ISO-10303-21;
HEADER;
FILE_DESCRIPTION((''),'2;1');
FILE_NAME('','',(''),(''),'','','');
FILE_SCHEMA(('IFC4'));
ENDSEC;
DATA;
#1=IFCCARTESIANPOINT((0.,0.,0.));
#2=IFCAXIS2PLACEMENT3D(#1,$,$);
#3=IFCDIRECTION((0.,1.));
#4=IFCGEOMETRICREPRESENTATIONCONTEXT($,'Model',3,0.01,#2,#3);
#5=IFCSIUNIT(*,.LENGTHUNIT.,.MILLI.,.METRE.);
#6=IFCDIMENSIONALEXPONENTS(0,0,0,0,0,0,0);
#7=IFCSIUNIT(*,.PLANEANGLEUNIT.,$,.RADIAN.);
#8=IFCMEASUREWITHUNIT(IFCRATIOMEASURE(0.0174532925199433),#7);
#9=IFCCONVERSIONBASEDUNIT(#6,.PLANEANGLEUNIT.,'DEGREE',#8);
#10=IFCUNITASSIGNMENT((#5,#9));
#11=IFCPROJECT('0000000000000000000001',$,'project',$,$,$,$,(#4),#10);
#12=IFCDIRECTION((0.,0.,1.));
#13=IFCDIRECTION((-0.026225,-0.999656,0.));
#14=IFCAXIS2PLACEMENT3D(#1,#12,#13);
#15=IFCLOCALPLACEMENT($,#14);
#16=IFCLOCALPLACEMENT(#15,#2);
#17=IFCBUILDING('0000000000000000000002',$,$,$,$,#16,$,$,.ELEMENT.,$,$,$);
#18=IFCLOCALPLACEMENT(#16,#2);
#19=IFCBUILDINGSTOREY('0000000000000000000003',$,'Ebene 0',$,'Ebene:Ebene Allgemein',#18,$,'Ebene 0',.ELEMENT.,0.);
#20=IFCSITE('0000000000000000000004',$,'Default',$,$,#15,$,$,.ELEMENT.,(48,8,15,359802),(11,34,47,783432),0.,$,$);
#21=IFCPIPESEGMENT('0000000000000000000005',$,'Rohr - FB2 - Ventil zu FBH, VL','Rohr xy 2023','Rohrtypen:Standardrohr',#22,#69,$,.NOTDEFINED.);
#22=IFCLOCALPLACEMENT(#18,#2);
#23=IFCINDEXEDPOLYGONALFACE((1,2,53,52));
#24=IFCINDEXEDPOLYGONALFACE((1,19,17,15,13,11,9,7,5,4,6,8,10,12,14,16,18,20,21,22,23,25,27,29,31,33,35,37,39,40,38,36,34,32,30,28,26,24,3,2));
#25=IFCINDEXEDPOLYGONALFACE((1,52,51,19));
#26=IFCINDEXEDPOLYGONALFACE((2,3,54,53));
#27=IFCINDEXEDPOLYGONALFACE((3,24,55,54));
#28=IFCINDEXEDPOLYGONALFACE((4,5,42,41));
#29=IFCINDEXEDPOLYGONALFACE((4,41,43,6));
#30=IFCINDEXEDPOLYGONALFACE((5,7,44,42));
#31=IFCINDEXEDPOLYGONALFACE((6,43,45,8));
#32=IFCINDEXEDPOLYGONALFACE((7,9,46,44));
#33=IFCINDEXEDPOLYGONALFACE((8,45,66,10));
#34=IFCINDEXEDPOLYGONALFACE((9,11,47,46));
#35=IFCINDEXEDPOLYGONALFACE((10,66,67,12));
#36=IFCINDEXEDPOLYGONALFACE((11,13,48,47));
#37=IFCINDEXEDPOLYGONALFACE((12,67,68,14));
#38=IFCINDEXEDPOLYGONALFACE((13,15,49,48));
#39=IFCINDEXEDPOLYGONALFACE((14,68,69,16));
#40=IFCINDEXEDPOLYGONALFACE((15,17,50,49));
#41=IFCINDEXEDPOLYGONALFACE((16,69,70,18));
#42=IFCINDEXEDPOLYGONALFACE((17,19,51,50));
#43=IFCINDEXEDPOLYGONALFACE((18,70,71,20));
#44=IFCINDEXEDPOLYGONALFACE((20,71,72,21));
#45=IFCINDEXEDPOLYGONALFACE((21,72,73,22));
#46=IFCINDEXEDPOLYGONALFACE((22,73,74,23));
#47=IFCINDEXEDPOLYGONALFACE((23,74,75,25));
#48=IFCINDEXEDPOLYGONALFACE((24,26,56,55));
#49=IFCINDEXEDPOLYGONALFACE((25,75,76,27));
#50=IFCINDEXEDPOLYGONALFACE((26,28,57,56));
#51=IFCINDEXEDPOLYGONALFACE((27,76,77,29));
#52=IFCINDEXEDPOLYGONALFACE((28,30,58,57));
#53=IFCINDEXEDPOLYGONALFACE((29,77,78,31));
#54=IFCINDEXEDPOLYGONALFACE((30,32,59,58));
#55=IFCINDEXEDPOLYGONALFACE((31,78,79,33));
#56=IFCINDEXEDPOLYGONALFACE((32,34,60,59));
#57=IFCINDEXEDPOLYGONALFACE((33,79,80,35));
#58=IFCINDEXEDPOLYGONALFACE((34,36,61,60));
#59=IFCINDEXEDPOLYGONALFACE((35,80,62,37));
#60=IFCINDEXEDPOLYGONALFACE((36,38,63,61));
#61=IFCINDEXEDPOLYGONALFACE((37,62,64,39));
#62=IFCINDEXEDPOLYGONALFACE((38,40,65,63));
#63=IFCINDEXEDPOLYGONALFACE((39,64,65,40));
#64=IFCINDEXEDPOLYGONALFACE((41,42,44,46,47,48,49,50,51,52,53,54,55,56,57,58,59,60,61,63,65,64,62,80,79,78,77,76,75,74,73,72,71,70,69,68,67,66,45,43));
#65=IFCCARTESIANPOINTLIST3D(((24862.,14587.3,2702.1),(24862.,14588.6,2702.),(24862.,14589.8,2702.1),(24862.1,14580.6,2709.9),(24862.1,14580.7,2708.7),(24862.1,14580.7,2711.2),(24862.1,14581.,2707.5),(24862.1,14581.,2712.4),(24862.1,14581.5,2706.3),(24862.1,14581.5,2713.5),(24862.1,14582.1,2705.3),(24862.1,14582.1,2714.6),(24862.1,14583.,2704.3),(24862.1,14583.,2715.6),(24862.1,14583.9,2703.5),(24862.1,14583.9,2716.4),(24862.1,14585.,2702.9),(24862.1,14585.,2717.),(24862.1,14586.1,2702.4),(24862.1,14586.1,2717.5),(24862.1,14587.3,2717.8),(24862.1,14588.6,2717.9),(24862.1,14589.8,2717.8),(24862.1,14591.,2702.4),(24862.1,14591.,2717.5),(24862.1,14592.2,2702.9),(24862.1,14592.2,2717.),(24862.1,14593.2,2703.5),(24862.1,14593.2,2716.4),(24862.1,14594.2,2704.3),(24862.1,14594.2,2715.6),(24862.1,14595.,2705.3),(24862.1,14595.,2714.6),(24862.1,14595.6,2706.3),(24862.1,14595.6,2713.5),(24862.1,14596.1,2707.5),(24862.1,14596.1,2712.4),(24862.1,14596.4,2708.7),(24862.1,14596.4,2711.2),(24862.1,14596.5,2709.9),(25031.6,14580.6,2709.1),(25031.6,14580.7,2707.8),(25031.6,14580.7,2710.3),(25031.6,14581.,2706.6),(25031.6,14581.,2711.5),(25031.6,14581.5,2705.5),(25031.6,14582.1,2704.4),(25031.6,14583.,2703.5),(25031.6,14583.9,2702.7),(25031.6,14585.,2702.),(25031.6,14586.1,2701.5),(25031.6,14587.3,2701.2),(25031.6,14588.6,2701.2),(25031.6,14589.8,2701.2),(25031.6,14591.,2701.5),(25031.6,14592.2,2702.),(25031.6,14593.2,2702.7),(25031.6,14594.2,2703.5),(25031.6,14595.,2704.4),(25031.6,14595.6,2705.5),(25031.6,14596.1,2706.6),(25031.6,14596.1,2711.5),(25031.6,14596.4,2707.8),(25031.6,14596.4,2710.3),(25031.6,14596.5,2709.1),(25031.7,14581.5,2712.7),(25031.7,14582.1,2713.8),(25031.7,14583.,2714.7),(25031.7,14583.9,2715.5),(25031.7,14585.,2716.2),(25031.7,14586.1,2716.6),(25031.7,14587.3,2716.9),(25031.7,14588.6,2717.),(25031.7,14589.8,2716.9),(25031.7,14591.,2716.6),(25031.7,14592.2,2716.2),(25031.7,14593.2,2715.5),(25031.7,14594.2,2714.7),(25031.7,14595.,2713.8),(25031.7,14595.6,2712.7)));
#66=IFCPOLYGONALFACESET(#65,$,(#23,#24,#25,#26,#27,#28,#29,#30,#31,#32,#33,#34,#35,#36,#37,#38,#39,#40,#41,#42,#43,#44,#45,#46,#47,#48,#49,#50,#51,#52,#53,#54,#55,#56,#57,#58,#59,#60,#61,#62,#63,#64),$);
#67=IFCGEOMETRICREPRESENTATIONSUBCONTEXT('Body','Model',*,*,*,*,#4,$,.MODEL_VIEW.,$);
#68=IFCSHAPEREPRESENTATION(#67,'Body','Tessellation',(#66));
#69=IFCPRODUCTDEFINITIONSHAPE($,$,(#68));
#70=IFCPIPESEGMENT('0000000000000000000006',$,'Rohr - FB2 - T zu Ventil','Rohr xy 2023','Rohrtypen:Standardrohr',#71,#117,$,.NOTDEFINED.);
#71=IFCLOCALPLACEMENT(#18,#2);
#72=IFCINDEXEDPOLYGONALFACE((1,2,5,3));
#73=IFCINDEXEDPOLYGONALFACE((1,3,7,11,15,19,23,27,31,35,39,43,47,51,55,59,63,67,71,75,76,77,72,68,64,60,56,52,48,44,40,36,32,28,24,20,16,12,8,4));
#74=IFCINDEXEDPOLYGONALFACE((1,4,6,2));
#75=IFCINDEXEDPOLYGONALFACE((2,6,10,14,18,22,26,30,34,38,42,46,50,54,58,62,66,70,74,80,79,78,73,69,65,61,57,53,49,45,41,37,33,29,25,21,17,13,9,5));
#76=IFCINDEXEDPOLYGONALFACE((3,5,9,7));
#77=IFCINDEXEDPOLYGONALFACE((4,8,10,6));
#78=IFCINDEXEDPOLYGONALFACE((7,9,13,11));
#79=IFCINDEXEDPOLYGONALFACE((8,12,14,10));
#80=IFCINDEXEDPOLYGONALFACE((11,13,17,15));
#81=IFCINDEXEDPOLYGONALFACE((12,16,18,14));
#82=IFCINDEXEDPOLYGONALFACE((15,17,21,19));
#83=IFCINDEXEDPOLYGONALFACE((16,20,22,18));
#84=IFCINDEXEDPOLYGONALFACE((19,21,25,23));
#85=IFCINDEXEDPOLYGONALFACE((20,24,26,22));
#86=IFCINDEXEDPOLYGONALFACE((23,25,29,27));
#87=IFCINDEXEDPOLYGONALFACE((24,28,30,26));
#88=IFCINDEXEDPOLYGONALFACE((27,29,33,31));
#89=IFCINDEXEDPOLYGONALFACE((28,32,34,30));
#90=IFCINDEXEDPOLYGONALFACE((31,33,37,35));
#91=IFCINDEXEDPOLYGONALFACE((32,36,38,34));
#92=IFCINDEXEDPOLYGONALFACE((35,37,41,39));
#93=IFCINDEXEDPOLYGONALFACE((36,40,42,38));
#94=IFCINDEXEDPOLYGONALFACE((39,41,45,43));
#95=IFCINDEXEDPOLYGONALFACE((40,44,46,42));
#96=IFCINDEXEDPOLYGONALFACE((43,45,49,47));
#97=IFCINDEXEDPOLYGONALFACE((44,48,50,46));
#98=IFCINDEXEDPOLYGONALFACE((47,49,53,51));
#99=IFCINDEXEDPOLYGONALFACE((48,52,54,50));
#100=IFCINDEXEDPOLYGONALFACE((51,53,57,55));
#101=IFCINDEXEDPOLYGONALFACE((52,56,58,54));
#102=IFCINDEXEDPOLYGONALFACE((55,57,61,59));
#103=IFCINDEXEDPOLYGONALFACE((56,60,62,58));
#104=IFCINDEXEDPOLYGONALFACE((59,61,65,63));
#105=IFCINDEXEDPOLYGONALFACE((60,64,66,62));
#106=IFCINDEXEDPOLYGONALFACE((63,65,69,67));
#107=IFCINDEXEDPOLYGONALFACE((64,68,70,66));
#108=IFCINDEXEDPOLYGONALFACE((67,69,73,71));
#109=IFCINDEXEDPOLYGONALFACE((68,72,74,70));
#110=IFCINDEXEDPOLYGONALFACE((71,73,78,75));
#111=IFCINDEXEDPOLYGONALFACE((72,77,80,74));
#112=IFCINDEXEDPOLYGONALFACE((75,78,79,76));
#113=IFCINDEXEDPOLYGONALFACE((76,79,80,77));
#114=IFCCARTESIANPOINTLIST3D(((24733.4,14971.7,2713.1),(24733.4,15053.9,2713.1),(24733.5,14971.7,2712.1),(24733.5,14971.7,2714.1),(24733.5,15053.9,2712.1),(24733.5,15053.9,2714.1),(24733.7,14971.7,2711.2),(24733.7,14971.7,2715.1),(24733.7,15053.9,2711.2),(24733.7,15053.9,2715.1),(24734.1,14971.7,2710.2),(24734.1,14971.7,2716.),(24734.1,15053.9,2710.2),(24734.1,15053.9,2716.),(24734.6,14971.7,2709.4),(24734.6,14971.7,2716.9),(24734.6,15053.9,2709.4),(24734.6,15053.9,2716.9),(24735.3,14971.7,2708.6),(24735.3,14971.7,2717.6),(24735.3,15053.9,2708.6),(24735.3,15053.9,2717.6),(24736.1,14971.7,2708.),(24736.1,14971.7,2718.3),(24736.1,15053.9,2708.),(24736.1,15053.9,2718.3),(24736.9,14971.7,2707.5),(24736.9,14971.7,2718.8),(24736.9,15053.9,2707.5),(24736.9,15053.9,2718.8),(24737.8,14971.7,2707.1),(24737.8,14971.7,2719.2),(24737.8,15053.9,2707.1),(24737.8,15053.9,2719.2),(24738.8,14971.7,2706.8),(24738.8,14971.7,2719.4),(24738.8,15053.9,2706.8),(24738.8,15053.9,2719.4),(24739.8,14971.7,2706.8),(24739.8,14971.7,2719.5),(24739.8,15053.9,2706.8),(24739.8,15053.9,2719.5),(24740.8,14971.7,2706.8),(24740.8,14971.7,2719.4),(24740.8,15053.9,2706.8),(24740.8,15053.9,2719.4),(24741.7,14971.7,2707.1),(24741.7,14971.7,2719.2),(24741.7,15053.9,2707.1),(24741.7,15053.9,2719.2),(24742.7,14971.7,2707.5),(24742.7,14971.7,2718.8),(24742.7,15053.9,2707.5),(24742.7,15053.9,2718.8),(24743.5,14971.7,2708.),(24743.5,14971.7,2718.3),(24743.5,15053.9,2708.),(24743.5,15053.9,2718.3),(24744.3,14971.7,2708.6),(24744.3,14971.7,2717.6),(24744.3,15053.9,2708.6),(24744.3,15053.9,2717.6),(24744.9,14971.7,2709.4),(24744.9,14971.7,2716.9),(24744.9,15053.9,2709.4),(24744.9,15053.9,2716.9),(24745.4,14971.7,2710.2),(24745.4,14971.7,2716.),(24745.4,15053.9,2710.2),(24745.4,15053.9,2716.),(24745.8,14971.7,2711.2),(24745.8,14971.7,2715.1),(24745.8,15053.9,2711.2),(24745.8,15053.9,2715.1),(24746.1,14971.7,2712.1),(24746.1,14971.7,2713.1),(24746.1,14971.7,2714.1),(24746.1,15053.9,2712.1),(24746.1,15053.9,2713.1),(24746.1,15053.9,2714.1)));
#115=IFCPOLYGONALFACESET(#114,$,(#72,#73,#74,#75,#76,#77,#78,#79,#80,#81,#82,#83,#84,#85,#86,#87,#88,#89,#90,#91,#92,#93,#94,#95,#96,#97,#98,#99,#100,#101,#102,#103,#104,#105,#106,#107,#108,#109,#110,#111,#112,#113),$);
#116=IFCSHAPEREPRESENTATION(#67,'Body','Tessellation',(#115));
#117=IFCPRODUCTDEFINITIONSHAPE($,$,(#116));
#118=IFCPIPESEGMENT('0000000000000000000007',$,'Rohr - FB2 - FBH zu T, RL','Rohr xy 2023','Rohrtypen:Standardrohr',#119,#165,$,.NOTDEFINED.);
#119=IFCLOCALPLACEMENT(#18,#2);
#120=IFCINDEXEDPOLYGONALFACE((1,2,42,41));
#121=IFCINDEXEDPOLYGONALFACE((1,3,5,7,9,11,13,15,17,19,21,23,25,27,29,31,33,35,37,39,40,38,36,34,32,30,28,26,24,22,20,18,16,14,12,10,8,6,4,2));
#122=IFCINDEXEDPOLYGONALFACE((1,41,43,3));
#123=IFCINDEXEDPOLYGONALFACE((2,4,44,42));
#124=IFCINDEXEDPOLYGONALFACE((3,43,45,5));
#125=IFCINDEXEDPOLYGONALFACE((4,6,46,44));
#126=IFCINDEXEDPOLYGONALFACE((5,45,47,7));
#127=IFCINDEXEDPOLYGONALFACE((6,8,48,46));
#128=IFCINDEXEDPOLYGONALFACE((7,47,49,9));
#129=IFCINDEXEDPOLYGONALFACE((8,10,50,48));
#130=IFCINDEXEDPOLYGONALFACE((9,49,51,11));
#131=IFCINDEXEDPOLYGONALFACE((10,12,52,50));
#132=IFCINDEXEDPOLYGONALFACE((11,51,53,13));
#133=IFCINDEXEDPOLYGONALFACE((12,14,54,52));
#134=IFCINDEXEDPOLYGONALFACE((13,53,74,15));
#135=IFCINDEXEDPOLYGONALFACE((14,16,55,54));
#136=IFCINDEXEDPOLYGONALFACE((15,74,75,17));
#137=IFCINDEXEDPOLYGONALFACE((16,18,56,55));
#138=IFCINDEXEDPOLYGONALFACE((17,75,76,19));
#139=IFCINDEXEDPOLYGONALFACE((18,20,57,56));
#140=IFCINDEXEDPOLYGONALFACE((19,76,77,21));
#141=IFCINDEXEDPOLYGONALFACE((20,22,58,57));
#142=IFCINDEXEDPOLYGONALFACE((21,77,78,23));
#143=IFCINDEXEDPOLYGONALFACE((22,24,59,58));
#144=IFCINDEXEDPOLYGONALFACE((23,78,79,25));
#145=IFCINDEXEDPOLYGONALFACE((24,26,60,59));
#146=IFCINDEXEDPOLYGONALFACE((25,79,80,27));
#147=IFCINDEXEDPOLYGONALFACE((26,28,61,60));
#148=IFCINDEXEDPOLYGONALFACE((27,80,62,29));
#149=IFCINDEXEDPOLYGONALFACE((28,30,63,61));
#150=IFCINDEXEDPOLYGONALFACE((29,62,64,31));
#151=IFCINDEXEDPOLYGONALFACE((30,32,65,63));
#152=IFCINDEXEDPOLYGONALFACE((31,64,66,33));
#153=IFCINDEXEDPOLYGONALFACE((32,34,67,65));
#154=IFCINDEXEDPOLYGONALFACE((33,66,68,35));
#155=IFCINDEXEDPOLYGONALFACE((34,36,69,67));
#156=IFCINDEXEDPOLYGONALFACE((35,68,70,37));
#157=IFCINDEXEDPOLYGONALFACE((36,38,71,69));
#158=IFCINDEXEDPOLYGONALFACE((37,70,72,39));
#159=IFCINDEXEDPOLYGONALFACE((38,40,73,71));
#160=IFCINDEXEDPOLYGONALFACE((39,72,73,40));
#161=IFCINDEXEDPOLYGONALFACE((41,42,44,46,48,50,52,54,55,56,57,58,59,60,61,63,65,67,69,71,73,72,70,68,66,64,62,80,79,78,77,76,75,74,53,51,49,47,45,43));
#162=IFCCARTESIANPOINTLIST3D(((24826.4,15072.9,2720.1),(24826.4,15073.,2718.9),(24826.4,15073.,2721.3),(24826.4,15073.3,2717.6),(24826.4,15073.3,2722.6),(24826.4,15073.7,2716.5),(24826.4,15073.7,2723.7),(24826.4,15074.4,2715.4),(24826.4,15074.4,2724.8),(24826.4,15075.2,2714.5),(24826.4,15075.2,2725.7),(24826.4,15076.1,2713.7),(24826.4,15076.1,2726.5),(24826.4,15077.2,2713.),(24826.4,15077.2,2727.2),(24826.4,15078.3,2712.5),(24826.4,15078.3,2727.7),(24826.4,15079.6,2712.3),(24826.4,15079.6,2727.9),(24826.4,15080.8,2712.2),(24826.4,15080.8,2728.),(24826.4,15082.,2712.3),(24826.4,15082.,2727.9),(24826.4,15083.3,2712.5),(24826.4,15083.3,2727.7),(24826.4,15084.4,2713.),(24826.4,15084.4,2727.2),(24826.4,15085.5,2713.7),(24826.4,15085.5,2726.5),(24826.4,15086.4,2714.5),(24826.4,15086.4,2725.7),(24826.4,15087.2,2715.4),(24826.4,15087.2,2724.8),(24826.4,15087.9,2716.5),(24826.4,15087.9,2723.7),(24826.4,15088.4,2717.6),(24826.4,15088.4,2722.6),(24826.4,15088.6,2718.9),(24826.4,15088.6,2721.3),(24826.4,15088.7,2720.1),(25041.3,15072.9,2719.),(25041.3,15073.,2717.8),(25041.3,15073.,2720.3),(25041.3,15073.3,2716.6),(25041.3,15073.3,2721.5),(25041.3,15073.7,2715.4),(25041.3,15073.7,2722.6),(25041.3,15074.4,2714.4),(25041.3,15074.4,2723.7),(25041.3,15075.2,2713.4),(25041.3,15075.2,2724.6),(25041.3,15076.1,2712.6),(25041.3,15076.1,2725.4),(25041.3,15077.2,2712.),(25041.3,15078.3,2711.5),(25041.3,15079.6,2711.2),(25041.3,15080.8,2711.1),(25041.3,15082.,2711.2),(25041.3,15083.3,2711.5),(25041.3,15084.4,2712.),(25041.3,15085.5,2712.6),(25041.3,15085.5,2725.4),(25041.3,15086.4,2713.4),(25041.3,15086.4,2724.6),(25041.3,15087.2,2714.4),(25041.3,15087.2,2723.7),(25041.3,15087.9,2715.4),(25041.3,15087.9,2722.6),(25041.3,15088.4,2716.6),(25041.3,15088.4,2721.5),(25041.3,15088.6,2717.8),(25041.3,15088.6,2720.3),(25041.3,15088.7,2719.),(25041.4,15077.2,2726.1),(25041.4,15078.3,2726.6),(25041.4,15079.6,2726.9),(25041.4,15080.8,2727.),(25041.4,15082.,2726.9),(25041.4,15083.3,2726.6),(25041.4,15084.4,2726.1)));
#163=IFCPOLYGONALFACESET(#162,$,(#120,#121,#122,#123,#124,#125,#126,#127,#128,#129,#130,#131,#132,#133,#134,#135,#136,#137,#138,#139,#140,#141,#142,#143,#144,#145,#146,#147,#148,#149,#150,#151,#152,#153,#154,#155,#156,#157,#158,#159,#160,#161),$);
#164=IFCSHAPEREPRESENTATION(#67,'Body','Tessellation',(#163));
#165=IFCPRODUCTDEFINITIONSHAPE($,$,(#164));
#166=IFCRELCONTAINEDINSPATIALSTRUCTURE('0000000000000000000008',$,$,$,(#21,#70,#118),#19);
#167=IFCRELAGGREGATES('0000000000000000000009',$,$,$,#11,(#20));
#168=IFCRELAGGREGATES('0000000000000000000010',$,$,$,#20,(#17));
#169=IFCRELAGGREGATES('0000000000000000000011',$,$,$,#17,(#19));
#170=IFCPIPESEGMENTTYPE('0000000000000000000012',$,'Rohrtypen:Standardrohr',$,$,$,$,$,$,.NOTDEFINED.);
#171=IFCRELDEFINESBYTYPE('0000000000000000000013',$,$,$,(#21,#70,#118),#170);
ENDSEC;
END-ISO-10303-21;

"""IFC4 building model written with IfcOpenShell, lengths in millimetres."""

from ifc_helpers import new_model, entity, si_unit, converted_unit, direction, frame, origin, place, context, subcontext, project, spatial, indexed_curve, outline, extrude, type_object, element, save


model = new_model("IFC4")

# Units and contexts
model_context = context("Model", 3, precision=0.01, world=origin(), true_north=direction((0.0, 1.0)))
body_context = subcontext(model_context, "Body", "Model", "MODEL_VIEW")
ifc_project = project(units=[si_unit("LENGTHUNIT", "METRE", prefix="MILLI"), converted_unit("PLANEANGLEUNIT", "DEGREE", entity("IfcRatioMeasure", 0.0174532925199433), si_unit("PLANEANGLEUNIT", "RADIAN"), dimensions=[0, 0, 0, 0, 0, 0, 0])], contexts=[model_context])

# Site, building, storey
site_placement = place(None, frame((0.0, 0.0, 0.0), z_axis=(0.0, 0.0, 1.0), x_axis=(-0.026225, -0.999656, 0.0)))
site = spatial("IfcSite", under=ifc_project, at=site_placement, Name="Default", CompositionType="ELEMENT", RefLatitude=(48, 8, 15, 359802), RefLongitude=(11, 34, 47, 783432), RefElevation=0.0)
building_placement = place(site_placement, origin())
building = spatial("IfcBuilding", under=site, at=building_placement, CompositionType="ELEMENT")
storey_placement = place(building_placement, origin())
storey = spatial("IfcBuildingStorey", under=building, at=storey_placement, Name="Ebene 0", ObjectType="Ebene:Ebene Allgemein", LongName="Ebene 0", CompositionType="ELEMENT", Elevation=0.0)

# Pipe segments
pipe_segment_type = type_object("IfcPipeSegmentType", Name="Rohrtypen:Standardrohr", PredefinedType="NOTDEFINED")
pipe_segment_1_placement = place(storey_placement, origin())
element("IfcPipeSegment", 1, at=pipe_segment_1_placement, inside=storey, type_object=pipe_segment_type, Name="Rohr - FB2 - Ventil zu FBH, VL", Description="Rohr xy 2023", ObjectType="Rohrtypen:Standardrohr", PredefinedType="NOTDEFINED", context=body_context, shape_type="SweptSolid", body=[
    extrude(outline(indexed_curve([(7.9, 0.0), (7.8, 1.2), (7.6, 2.5), (7.1, 3.6), (6.4, 4.7), (5.6, 5.6), (4.7, 6.4), (3.6, 7.1), (2.5, 7.6), (1.2, 7.8), (0.0, 7.9), (-1.2, 7.8), (-2.5, 7.6), (-3.6, 7.1), (-4.7, 6.4), (-5.6, 5.6), (-6.4, 4.7), (-7.1, 3.6), (-7.6, 2.5), (-7.8, 1.2), (-7.9, 0.0), (-7.8, -1.2), (-7.6, -2.5), (-7.1, -3.6), (-6.4, -4.7), (-5.6, -5.6), (-4.7, -6.4), (-3.6, -7.1), (-2.5, -7.6), (-1.2, -7.8), (0.0, -7.9), (1.2, -7.8), (2.5, -7.6), (3.6, -7.1), (4.7, -6.4), (5.6, -5.6), (6.4, -4.7), (7.1, -3.6), (7.6, -2.5), (7.8, -1.2), (7.9, 0.0)], self_intersect=False)), frame((24862.1, 14588.6, 2709.9), z_axis=(0.999988, 0.0, -0.005), x_axis=(0.0, 1.0, 0.0)), (0.0, 0.0, 1.0), 169.5),
])
pipe_segment_2_placement = place(storey_placement, origin())
element("IfcPipeSegment", 2, at=pipe_segment_2_placement, inside=storey, type_object=pipe_segment_type, Name="Rohr - FB2 - T zu Ventil", Description="Rohr xy 2023", ObjectType="Rohrtypen:Standardrohr", PredefinedType="NOTDEFINED", context=body_context, shape_type="SweptSolid", body=[
    extrude(outline(indexed_curve([(6.3, 0.0), (6.3, 1.0), (6.0, 2.0), (5.7, 2.9), (5.1, 3.7), (4.5, 4.5), (3.7, 5.1), (2.9, 5.7), (2.0, 6.0), (1.0, 6.3), (0.0, 6.4), (-1.0, 6.3), (-2.0, 6.0), (-2.9, 5.7), (-3.7, 5.1), (-4.5, 4.5), (-5.1, 3.7), (-5.7, 2.9), (-6.0, 2.0), (-6.3, 1.0), (-6.3, 0.0), (-6.3, -1.0), (-6.0, -2.0), (-5.7, -2.9), (-5.1, -3.7), (-4.5, -4.5), (-3.7, -5.1), (-2.9, -5.7), (-2.0, -6.0), (-1.0, -6.3), (0.0, -6.4), (1.0, -6.3), (2.0, -6.0), (2.9, -5.7), (3.7, -5.1), (4.5, -4.5), (5.1, -3.7), (5.7, -2.9), (6.0, -2.0), (6.3, -1.0), (6.3, 0.0)], self_intersect=False)), frame((24739.8, 14971.7, 2713.1), z_axis=(0.0, 1.0, 0.0), x_axis=(-1.0, 0.0, 0.0)), (0.0, 0.0, 1.0), 82.2),
])
pipe_segment_3_placement = place(storey_placement, origin())
element("IfcPipeSegment", 3, at=pipe_segment_3_placement, inside=storey, type_object=pipe_segment_type, Name="Rohr - FB2 - FBH zu T, RL", Description="Rohr xy 2023", ObjectType="Rohrtypen:Standardrohr", PredefinedType="NOTDEFINED", context=body_context, shape_type="SweptSolid", body=[
    extrude(outline(indexed_curve([(7.9, 0.0), (7.8, 1.2), (7.6, 2.5), (7.1, 3.6), (6.4, 4.7), (5.6, 5.6), (4.7, 6.4), (3.6, 7.1), (2.5, 7.6), (1.2, 7.8), (0.0, 7.9), (-1.2, 7.8), (-2.5, 7.6), (-3.6, 7.1), (-4.7, 6.4), (-5.6, 5.6), (-6.4, 4.7), (-7.1, 3.6), (-7.6, 2.5), (-7.8, 1.2), (-7.9, 0.0), (-7.8, -1.2), (-7.6, -2.5), (-7.1, -3.6), (-6.4, -4.7), (-5.6, -5.6), (-4.7, -6.4), (-3.6, -7.1), (-2.5, -7.6), (-1.2, -7.8), (0.0, -7.9), (1.2, -7.8), (2.5, -7.6), (3.6, -7.1), (4.7, -6.4), (5.6, -5.6), (6.4, -4.7), (7.1, -3.6), (7.6, -2.5), (7.8, -1.2), (7.9, 0.0)], self_intersect=False)), frame((25041.3, 15080.8, 2719.0), z_axis=(-0.999988, 0.0, 0.005), x_axis=(0.0, 1.0, 0.0)), (0.0, 0.0, 1.0), 214.9),
])

save(model, "model.ifc")
